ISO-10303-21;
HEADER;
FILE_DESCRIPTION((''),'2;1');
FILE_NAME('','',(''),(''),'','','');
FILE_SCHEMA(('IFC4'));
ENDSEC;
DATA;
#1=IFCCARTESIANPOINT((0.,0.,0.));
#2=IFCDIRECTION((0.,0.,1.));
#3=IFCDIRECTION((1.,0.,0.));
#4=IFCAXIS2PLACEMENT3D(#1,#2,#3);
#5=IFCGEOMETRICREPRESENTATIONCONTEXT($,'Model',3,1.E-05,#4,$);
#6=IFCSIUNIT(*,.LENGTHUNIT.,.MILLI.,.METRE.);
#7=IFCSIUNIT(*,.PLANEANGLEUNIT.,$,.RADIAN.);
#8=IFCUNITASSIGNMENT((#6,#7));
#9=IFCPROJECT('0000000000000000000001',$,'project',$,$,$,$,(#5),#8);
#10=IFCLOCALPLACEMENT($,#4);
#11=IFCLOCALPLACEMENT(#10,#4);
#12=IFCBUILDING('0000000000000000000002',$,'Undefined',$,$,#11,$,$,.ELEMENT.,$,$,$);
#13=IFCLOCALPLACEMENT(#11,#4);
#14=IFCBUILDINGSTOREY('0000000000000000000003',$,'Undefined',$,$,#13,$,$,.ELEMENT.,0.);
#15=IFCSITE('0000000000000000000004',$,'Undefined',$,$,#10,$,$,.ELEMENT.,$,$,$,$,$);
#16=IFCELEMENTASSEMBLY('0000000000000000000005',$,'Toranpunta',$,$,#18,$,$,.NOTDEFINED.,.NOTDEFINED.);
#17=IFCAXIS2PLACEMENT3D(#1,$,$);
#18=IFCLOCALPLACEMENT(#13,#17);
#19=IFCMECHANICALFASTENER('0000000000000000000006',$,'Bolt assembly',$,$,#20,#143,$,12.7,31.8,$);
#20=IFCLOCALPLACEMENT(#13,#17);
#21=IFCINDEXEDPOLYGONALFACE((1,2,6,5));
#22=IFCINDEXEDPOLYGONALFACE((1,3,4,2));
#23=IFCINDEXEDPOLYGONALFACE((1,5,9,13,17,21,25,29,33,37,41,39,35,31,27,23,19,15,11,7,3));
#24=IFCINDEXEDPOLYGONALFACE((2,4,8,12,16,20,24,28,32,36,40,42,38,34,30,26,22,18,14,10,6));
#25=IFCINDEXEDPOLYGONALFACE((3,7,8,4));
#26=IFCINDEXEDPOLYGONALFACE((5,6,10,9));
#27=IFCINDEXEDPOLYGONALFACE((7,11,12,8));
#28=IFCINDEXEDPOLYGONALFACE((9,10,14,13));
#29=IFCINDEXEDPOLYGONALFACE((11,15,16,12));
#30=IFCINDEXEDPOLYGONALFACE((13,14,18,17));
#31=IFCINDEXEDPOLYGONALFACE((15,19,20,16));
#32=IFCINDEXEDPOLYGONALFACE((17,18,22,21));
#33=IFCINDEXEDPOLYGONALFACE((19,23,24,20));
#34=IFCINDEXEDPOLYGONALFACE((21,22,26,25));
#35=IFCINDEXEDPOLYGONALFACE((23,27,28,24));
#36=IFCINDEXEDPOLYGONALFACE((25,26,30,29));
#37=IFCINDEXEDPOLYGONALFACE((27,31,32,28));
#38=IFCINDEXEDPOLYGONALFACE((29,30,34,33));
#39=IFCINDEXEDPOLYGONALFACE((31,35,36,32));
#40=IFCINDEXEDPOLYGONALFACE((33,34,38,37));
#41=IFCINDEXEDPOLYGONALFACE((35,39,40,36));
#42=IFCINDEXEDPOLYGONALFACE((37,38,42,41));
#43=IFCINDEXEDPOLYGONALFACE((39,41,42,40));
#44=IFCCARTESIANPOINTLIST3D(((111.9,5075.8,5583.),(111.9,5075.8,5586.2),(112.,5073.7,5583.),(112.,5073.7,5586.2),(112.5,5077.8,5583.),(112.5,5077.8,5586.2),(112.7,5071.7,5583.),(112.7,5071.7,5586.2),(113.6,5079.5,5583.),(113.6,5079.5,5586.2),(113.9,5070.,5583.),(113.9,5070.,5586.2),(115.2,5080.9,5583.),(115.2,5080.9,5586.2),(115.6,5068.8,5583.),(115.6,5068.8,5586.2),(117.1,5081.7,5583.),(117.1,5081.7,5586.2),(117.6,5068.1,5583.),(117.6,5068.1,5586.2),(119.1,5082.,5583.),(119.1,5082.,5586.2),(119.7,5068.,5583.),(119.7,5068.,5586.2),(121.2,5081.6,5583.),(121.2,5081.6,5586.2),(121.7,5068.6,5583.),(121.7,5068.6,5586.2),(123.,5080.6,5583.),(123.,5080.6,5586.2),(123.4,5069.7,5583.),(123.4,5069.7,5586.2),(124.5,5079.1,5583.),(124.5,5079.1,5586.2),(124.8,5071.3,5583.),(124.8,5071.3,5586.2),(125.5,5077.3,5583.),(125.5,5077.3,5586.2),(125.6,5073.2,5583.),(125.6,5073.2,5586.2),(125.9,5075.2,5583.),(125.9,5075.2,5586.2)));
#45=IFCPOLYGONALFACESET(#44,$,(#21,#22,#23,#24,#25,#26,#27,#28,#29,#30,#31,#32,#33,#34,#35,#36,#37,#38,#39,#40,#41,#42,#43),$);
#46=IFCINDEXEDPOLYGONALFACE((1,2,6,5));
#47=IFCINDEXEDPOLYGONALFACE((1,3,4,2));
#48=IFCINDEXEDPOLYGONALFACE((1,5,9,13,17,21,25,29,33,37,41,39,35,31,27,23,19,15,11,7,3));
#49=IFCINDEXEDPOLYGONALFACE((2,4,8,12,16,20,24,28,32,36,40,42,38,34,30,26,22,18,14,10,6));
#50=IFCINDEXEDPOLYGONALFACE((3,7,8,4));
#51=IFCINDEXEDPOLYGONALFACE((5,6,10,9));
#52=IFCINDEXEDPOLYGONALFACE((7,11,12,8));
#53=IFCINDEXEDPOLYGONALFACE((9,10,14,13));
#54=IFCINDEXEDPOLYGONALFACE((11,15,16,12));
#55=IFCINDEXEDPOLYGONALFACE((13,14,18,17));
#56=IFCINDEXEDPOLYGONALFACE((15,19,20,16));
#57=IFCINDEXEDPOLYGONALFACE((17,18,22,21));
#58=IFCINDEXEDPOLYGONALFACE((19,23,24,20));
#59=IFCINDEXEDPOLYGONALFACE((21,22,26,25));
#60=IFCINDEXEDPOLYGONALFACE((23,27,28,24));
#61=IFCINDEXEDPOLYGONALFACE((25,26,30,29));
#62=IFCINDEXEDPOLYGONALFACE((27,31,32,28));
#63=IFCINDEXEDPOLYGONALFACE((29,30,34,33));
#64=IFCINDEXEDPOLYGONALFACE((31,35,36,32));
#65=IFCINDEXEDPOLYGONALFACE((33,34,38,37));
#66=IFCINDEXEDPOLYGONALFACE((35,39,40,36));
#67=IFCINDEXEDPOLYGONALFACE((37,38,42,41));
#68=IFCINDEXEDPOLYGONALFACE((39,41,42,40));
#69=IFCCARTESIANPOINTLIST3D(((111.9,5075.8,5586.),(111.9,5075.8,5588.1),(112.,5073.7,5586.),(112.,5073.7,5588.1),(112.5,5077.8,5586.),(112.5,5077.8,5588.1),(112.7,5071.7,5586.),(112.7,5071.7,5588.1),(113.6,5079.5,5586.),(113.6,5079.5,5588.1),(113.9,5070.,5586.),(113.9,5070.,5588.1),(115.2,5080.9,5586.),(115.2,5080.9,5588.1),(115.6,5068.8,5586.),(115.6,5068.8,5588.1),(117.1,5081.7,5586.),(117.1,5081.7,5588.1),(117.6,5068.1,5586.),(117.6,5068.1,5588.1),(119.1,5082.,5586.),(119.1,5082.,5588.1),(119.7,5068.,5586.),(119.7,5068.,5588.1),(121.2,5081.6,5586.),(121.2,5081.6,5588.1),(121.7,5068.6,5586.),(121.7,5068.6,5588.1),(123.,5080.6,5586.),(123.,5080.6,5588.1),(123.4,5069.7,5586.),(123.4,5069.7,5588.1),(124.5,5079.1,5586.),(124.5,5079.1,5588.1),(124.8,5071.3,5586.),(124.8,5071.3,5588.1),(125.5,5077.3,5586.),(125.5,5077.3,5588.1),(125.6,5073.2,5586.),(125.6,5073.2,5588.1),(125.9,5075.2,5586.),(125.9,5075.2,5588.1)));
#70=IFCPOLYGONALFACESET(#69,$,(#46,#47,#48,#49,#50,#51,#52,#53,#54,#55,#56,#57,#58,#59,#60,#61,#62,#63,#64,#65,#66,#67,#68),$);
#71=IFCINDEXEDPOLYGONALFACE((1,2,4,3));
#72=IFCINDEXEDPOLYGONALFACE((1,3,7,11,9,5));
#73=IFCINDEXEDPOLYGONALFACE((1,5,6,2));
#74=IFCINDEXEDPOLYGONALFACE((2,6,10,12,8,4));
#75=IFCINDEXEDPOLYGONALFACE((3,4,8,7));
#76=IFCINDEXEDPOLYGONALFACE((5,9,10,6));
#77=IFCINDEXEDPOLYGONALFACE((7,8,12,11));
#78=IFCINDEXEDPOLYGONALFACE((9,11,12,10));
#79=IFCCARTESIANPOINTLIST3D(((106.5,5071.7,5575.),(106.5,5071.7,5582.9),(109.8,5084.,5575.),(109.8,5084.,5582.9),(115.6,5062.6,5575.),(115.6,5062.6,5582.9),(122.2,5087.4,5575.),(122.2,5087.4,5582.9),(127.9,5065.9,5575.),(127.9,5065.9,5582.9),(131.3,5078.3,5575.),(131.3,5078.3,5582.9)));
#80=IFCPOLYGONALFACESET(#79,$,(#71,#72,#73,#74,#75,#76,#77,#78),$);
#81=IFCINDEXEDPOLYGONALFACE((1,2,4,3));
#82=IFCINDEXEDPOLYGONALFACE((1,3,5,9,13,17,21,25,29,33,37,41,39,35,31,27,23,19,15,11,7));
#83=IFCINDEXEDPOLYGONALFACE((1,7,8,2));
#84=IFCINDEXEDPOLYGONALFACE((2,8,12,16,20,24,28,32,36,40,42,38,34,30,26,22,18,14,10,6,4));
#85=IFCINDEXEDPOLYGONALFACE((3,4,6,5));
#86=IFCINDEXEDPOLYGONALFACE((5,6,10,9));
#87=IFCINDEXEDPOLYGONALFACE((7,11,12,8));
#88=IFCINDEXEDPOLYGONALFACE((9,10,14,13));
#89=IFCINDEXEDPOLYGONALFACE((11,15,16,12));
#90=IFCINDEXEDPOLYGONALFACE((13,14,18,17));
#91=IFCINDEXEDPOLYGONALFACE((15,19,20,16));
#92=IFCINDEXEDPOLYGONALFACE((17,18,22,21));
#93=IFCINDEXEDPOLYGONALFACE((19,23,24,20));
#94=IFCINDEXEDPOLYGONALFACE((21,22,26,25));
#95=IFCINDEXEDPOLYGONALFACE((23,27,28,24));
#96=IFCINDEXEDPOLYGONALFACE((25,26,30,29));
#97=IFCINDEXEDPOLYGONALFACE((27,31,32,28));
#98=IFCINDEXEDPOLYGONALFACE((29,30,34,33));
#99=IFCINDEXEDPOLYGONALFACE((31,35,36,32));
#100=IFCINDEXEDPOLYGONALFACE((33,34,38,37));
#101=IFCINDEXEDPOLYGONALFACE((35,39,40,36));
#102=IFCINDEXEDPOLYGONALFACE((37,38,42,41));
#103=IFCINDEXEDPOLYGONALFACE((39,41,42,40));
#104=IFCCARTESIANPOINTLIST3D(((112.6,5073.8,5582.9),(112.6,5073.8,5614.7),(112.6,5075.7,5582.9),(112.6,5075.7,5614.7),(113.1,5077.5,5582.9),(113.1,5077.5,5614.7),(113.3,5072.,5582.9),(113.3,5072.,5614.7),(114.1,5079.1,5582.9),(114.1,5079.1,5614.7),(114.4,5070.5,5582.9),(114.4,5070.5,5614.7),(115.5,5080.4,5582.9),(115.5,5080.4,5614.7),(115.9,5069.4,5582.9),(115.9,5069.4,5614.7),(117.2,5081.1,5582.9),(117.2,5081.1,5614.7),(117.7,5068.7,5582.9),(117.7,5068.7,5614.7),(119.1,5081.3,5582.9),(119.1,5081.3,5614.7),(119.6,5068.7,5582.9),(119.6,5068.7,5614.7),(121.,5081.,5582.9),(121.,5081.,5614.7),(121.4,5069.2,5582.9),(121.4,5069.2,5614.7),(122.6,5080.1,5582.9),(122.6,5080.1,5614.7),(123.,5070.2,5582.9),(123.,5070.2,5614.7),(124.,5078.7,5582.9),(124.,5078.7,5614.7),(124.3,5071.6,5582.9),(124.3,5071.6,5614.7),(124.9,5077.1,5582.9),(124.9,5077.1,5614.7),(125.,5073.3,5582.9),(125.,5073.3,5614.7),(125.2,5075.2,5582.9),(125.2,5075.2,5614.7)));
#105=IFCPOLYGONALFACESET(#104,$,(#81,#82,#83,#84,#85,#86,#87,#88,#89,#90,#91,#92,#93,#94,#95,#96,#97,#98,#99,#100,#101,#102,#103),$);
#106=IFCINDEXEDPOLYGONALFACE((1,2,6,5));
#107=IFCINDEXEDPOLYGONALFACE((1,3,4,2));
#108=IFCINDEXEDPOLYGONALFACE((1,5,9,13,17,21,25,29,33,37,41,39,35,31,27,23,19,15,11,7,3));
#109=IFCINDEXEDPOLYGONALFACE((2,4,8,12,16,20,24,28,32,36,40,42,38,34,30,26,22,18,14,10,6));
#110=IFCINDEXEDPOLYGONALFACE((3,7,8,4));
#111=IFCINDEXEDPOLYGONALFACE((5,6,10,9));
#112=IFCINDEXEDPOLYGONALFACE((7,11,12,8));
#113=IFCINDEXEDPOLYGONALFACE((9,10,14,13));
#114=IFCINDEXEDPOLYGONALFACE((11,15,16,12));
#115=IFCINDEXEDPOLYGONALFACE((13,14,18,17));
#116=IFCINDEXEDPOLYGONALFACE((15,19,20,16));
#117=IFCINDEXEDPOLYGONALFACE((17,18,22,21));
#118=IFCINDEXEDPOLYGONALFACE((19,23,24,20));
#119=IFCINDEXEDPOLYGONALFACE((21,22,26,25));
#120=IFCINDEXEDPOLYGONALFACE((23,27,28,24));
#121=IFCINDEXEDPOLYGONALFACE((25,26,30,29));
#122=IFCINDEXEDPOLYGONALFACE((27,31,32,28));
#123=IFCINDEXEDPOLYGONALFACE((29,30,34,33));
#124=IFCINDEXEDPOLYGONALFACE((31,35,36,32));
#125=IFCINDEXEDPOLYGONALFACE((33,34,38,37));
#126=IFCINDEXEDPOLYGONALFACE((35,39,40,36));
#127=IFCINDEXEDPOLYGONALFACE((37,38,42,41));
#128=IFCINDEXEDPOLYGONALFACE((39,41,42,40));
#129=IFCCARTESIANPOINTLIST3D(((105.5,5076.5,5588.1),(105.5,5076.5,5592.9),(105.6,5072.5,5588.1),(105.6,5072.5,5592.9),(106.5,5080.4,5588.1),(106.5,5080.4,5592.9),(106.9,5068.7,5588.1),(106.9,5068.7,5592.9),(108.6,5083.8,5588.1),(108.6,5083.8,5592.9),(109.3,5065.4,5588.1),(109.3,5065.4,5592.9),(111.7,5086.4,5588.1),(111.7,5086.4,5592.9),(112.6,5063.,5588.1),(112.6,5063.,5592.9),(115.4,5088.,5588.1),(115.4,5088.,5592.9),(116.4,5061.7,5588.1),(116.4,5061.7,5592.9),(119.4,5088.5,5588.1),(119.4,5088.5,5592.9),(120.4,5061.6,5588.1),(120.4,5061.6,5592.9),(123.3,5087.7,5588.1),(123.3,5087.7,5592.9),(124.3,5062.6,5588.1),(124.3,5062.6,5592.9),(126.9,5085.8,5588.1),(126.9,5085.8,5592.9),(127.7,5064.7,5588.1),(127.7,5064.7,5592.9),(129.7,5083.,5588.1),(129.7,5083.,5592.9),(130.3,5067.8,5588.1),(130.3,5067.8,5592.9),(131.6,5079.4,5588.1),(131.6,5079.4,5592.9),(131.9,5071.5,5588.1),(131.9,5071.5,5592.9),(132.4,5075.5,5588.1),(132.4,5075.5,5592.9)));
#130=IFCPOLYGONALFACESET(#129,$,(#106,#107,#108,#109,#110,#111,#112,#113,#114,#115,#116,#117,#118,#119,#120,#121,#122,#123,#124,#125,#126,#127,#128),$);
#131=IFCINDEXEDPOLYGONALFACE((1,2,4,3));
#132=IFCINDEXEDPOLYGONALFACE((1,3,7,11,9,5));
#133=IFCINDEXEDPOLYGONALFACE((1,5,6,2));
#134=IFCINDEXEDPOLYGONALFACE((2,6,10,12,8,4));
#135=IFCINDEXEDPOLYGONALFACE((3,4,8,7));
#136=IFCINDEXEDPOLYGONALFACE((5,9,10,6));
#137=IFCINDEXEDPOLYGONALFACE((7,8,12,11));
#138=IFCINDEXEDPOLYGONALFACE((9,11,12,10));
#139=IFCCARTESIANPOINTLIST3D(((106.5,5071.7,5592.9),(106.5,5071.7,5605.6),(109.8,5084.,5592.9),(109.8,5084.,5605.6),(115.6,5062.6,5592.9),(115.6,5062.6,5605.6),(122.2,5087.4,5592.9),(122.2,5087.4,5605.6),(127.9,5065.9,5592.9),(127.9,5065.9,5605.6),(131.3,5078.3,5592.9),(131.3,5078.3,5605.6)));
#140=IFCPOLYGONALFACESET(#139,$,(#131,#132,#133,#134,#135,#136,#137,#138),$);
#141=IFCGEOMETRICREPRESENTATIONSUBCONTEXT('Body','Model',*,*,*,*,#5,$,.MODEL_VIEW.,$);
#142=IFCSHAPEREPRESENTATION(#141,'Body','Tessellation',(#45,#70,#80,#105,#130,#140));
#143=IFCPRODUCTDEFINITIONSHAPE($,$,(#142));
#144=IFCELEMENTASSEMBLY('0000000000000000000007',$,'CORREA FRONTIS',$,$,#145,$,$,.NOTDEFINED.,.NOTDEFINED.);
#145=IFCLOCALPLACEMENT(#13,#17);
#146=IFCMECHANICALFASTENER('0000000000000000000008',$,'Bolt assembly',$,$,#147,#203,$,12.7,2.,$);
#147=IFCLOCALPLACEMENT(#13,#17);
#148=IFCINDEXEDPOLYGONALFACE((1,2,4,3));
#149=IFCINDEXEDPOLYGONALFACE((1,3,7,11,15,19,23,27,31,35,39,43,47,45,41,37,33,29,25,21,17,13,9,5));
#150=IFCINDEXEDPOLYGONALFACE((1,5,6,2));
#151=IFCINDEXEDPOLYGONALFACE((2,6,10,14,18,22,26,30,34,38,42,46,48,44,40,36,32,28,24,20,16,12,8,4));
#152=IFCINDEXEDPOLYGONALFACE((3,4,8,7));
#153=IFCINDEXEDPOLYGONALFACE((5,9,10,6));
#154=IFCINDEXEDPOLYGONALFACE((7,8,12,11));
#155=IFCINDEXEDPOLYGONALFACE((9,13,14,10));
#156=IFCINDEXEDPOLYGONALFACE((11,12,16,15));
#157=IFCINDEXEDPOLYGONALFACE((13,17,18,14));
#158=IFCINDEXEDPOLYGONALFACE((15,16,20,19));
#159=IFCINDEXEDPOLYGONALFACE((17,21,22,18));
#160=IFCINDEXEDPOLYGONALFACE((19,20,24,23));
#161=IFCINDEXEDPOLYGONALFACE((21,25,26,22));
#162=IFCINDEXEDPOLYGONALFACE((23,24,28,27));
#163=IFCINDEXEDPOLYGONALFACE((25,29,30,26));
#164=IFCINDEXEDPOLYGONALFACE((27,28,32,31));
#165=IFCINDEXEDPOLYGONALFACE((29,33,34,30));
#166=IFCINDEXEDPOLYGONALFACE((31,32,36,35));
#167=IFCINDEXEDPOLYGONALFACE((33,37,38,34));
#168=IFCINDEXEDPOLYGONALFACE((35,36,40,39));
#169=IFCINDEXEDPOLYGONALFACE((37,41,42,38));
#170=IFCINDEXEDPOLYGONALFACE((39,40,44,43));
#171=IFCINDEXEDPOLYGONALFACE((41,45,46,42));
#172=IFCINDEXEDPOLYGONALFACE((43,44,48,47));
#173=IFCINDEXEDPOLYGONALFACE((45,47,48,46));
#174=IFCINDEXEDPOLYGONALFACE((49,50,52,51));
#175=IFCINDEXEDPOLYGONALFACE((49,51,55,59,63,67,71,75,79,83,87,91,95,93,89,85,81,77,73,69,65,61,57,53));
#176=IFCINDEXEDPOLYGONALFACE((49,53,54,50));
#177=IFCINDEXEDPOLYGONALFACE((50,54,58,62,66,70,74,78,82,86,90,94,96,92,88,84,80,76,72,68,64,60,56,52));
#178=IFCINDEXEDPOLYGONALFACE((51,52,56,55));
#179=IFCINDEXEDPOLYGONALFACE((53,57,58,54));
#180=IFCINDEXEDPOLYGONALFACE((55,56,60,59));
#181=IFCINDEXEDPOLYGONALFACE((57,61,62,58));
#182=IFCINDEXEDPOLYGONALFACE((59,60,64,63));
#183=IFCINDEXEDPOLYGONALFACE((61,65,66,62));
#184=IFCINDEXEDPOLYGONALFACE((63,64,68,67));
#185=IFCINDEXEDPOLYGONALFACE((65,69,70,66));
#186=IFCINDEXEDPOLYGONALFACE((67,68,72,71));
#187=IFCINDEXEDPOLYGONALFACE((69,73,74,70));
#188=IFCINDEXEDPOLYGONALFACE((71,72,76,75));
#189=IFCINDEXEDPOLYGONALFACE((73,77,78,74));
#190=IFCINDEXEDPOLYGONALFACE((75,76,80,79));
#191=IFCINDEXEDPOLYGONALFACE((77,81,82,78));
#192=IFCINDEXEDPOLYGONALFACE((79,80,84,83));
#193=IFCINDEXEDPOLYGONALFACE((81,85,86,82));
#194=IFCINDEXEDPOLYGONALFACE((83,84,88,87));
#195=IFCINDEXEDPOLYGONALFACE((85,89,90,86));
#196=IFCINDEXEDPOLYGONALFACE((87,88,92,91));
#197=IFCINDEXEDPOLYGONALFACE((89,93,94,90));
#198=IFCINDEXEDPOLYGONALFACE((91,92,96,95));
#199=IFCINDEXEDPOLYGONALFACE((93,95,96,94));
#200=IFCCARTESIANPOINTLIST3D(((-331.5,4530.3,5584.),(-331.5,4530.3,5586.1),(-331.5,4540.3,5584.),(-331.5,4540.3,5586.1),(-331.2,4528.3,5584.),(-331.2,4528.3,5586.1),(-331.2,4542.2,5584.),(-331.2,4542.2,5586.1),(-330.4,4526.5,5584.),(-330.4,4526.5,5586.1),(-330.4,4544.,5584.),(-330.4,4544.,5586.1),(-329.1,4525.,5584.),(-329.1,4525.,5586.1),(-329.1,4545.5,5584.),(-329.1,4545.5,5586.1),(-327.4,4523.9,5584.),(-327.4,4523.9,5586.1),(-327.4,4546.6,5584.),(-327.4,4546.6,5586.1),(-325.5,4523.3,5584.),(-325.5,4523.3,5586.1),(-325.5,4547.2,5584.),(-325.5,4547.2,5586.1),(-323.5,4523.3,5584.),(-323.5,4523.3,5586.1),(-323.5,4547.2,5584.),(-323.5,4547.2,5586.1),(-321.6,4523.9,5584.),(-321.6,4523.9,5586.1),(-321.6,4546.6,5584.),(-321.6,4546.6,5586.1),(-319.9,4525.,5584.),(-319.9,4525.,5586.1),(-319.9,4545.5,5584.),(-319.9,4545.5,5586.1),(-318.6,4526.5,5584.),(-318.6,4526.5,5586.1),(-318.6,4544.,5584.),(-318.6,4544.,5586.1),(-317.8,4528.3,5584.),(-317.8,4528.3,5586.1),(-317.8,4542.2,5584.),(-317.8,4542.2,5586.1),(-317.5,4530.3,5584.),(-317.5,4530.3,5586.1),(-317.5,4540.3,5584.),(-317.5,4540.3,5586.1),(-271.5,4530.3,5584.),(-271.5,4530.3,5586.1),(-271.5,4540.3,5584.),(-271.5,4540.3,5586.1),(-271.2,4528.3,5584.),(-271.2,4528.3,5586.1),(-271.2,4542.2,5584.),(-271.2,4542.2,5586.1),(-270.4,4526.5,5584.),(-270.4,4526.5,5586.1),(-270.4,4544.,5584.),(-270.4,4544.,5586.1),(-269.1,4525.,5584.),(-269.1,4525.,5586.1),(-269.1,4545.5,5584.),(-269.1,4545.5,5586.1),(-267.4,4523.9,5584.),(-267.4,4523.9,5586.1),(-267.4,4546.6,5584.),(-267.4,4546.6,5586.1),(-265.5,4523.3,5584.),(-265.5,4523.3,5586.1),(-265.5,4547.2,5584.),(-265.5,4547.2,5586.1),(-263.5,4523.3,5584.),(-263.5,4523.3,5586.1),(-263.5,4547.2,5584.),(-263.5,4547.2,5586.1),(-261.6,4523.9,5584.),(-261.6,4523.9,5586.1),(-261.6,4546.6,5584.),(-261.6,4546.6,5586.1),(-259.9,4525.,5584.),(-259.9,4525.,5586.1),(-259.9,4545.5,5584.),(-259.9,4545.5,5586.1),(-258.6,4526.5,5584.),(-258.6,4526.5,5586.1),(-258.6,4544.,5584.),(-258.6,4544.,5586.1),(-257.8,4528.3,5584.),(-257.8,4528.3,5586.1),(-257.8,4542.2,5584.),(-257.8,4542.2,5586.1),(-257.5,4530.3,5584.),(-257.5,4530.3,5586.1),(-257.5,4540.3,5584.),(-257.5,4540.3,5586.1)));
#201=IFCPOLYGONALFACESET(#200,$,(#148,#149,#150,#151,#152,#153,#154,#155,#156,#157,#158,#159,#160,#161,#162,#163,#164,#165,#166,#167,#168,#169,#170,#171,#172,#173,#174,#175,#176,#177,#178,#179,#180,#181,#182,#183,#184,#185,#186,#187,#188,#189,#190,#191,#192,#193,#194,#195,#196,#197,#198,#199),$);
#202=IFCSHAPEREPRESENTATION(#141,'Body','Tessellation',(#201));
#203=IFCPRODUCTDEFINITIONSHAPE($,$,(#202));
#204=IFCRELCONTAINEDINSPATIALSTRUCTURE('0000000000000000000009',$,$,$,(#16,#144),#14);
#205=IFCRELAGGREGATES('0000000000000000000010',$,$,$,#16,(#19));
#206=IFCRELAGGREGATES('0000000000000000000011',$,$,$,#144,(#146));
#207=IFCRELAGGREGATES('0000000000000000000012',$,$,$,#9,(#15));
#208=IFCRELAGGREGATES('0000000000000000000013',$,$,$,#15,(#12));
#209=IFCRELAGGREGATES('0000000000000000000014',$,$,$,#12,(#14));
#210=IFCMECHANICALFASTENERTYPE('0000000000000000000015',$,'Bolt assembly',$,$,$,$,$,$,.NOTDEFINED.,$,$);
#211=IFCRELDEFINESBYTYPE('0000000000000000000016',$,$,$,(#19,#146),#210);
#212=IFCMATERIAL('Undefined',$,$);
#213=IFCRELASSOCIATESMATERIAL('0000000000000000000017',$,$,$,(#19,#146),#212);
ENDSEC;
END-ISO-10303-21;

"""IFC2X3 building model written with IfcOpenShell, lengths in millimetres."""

from ifc_helpers import new_model, si_unit, frame, frame_2d, origin_with_axes, origin_2d_with_axis, place, context, subcontext, project, spatial, polyline, circle_curve, parameter, trimmed, segment, composite_curve, circle, outline, extrude, source, transform, mapped, material, type_object, element, aggregate, save


model = new_model("IFC2X3")

# Units and contexts
model_context = context("Model", 3, precision=1e-05, world=origin_with_axes())
body_context = subcontext(model_context, "Body", "Model", "MODEL_VIEW")
ifc_project = project(units=[si_unit("LENGTHUNIT", "METRE", prefix="MILLI"), si_unit("PLANEANGLEUNIT", "RADIAN")], contexts=[model_context])

# Site, building, storey
site_placement = place(None, origin_with_axes())
site = spatial("IfcSite", under=ifc_project, at=site_placement, Name="Undefined", CompositionType="ELEMENT")
building_placement = place(site_placement, origin_with_axes())
building = spatial("IfcBuilding", under=site, at=building_placement, Name="Undefined", CompositionType="ELEMENT")
storey_placement = place(building_placement, origin_with_axes())
storey = spatial("IfcBuildingStorey", under=building, at=storey_placement, Name="Undefined", CompositionType="ELEMENT", Elevation=0.0)

# Element assembly, mechanical fastener
assembly_1_placement = place(storey_placement, origin_with_axes())
assembly_1 = element("IfcElementAssembly", 1, at=assembly_1_placement, inside=storey, Name="Toranpunta", AssemblyPlace="NOTDEFINED", PredefinedType="NOTDEFINED")
ifc_material_1 = material(Name="Undefined")
mechanical_fastener_type = type_object("IfcMechanicalFastenerType", Name="Bolt assembly")
shared_shape_1 = source(origin_with_axes(), body_context, "Body", "SweptSolid", [
    extrude(circle(Radius=7.0, at=origin_2d_with_axis()), frame((0.0, 0.1, 0.0), z_axis=(0.0, 1.0, 0.0), x_axis=(1.0, 0.0, 0.0)), (0.0, 0.0, 1.0), 3.2),
    extrude(circle(Radius=7.0, at=origin_2d_with_axis()), frame((0.0, 3.1, 0.0), z_axis=(0.0, 1.0, 0.0), x_axis=(1.0, 0.0, 0.0)), (0.0, 0.0, 1.0), 2.1),
    extrude(outline(polyline([(11.1, -6.4), (11.1, 6.4), (0.0, 12.8), (-11.1, 6.4), (-11.1, -6.4), (0.0, -12.8), (11.1, -6.4)])), frame((0.0, -7.9, 0.0), z_axis=(0.0, 1.0, 0.0), x_axis=(1.0, 0.0, 0.0)), (0.0, 0.0, 1.0), 7.9),
    extrude(circle(Radius=6.3, at=origin_2d_with_axis()), frame((0.0, 0.0, 0.0), z_axis=(0.0, 1.0, 0.0), x_axis=(1.0, 0.0, 0.0)), (0.0, 0.0, 1.0), 31.8),
    extrude(circle(Radius=13.5, at=origin_2d_with_axis()), frame((0.0, 5.2, 0.0), z_axis=(0.0, 1.0, 0.0), x_axis=(1.0, 0.0, 0.0)), (0.0, 0.0, 1.0), 4.8),
    extrude(outline(polyline([(11.1, -6.4), (11.1, 6.4), (0.0, 12.8), (-11.1, 6.4), (-11.1, -6.4), (0.0, -12.8), (11.1, -6.4)])), frame((0.0, 10.0, 0.0), z_axis=(0.0, 1.0, 0.0), x_axis=(1.0, 0.0, 0.0)), (0.0, 0.0, 1.0), 12.7),
])
mechanical_fastener_1_placement = place(assembly_1_placement, frame((118.9, 5075.0, 5582.9), z_axis=(-0.707107, 0.707106, 0.000005), x_axis=(-0.707106, -0.707107, 0.000005)))
mechanical_fastener_1 = element("IfcMechanicalFastener", 2, at=mechanical_fastener_1_placement, type_object=mechanical_fastener_type, material=ifc_material_1, Name="Bolt assembly", NominalDiameter=12.7, NominalLength=31.8, context=body_context, shape_type="MappedRepresentation", body=[
    mapped(shared_shape_1, transform((0.0, 0.0, 0.0))),
])
aggregate(assembly_1, [mechanical_fastener_1])

# Element assembly, mechanical fastener
assembly_2_placement = place(storey_placement, origin_with_axes())
assembly_2 = element("IfcElementAssembly", 3, at=assembly_2_placement, inside=storey, Name="CORREA FRONTIS", AssemblyPlace="NOTDEFINED", PredefinedType="NOTDEFINED")
shared_shape_2 = source(origin_with_axes(), body_context, "Body", "SweptSolid", [
    extrude(outline(composite_curve([segment(polyline([(7.0, 5.0), (7.0, -5.0)]), True, "CONTINUOUS"), segment(trimmed(circle_curve(frame_2d((0.0, -5.0), x_axis=(1.0, 0.0)), 7.0), [parameter(0.0)], [parameter(3.141593)], False, "PARAMETER"), True, "CONTINUOUS"), segment(polyline([(-7.0, -5.0), (-7.0, 5.0)]), True, "CONTINUOUS"), segment(trimmed(circle_curve(frame_2d((0.0, 5.0), x_axis=(-1.0, 0.0)), 7.0), [parameter(0.0)], [parameter(3.141593)], False, "PARAMETER"), True, "DISCONTINUOUS")], self_intersect=False)), frame((0.0, 0.0, 0.0), z_axis=(0.0, 1.0, 0.0), x_axis=(1.0, 0.0, 0.0)), (0.0, 0.0, 1.0), 2.1),
])
mechanical_fastener_2_placement = place(assembly_2_placement, frame((-324.5, 4535.3, 5586.1), z_axis=(-0.000002, 1.0, 0.0), x_axis=(1.0, 0.000002, 0.000004)))
mechanical_fastener_2 = element("IfcMechanicalFastener", 4, at=mechanical_fastener_2_placement, type_object=mechanical_fastener_type, material=ifc_material_1, Name="Bolt assembly", NominalDiameter=12.7, NominalLength=2.0, context=body_context, shape_type="MappedRepresentation", body=[
    mapped(shared_shape_2, transform((0.0, 0.0, 0.0))),
    mapped(shared_shape_2, transform((60.0, 0.0, 0.0))),
])

aggregate(assembly_2, [mechanical_fastener_2])

save(model, "model.ifc")
